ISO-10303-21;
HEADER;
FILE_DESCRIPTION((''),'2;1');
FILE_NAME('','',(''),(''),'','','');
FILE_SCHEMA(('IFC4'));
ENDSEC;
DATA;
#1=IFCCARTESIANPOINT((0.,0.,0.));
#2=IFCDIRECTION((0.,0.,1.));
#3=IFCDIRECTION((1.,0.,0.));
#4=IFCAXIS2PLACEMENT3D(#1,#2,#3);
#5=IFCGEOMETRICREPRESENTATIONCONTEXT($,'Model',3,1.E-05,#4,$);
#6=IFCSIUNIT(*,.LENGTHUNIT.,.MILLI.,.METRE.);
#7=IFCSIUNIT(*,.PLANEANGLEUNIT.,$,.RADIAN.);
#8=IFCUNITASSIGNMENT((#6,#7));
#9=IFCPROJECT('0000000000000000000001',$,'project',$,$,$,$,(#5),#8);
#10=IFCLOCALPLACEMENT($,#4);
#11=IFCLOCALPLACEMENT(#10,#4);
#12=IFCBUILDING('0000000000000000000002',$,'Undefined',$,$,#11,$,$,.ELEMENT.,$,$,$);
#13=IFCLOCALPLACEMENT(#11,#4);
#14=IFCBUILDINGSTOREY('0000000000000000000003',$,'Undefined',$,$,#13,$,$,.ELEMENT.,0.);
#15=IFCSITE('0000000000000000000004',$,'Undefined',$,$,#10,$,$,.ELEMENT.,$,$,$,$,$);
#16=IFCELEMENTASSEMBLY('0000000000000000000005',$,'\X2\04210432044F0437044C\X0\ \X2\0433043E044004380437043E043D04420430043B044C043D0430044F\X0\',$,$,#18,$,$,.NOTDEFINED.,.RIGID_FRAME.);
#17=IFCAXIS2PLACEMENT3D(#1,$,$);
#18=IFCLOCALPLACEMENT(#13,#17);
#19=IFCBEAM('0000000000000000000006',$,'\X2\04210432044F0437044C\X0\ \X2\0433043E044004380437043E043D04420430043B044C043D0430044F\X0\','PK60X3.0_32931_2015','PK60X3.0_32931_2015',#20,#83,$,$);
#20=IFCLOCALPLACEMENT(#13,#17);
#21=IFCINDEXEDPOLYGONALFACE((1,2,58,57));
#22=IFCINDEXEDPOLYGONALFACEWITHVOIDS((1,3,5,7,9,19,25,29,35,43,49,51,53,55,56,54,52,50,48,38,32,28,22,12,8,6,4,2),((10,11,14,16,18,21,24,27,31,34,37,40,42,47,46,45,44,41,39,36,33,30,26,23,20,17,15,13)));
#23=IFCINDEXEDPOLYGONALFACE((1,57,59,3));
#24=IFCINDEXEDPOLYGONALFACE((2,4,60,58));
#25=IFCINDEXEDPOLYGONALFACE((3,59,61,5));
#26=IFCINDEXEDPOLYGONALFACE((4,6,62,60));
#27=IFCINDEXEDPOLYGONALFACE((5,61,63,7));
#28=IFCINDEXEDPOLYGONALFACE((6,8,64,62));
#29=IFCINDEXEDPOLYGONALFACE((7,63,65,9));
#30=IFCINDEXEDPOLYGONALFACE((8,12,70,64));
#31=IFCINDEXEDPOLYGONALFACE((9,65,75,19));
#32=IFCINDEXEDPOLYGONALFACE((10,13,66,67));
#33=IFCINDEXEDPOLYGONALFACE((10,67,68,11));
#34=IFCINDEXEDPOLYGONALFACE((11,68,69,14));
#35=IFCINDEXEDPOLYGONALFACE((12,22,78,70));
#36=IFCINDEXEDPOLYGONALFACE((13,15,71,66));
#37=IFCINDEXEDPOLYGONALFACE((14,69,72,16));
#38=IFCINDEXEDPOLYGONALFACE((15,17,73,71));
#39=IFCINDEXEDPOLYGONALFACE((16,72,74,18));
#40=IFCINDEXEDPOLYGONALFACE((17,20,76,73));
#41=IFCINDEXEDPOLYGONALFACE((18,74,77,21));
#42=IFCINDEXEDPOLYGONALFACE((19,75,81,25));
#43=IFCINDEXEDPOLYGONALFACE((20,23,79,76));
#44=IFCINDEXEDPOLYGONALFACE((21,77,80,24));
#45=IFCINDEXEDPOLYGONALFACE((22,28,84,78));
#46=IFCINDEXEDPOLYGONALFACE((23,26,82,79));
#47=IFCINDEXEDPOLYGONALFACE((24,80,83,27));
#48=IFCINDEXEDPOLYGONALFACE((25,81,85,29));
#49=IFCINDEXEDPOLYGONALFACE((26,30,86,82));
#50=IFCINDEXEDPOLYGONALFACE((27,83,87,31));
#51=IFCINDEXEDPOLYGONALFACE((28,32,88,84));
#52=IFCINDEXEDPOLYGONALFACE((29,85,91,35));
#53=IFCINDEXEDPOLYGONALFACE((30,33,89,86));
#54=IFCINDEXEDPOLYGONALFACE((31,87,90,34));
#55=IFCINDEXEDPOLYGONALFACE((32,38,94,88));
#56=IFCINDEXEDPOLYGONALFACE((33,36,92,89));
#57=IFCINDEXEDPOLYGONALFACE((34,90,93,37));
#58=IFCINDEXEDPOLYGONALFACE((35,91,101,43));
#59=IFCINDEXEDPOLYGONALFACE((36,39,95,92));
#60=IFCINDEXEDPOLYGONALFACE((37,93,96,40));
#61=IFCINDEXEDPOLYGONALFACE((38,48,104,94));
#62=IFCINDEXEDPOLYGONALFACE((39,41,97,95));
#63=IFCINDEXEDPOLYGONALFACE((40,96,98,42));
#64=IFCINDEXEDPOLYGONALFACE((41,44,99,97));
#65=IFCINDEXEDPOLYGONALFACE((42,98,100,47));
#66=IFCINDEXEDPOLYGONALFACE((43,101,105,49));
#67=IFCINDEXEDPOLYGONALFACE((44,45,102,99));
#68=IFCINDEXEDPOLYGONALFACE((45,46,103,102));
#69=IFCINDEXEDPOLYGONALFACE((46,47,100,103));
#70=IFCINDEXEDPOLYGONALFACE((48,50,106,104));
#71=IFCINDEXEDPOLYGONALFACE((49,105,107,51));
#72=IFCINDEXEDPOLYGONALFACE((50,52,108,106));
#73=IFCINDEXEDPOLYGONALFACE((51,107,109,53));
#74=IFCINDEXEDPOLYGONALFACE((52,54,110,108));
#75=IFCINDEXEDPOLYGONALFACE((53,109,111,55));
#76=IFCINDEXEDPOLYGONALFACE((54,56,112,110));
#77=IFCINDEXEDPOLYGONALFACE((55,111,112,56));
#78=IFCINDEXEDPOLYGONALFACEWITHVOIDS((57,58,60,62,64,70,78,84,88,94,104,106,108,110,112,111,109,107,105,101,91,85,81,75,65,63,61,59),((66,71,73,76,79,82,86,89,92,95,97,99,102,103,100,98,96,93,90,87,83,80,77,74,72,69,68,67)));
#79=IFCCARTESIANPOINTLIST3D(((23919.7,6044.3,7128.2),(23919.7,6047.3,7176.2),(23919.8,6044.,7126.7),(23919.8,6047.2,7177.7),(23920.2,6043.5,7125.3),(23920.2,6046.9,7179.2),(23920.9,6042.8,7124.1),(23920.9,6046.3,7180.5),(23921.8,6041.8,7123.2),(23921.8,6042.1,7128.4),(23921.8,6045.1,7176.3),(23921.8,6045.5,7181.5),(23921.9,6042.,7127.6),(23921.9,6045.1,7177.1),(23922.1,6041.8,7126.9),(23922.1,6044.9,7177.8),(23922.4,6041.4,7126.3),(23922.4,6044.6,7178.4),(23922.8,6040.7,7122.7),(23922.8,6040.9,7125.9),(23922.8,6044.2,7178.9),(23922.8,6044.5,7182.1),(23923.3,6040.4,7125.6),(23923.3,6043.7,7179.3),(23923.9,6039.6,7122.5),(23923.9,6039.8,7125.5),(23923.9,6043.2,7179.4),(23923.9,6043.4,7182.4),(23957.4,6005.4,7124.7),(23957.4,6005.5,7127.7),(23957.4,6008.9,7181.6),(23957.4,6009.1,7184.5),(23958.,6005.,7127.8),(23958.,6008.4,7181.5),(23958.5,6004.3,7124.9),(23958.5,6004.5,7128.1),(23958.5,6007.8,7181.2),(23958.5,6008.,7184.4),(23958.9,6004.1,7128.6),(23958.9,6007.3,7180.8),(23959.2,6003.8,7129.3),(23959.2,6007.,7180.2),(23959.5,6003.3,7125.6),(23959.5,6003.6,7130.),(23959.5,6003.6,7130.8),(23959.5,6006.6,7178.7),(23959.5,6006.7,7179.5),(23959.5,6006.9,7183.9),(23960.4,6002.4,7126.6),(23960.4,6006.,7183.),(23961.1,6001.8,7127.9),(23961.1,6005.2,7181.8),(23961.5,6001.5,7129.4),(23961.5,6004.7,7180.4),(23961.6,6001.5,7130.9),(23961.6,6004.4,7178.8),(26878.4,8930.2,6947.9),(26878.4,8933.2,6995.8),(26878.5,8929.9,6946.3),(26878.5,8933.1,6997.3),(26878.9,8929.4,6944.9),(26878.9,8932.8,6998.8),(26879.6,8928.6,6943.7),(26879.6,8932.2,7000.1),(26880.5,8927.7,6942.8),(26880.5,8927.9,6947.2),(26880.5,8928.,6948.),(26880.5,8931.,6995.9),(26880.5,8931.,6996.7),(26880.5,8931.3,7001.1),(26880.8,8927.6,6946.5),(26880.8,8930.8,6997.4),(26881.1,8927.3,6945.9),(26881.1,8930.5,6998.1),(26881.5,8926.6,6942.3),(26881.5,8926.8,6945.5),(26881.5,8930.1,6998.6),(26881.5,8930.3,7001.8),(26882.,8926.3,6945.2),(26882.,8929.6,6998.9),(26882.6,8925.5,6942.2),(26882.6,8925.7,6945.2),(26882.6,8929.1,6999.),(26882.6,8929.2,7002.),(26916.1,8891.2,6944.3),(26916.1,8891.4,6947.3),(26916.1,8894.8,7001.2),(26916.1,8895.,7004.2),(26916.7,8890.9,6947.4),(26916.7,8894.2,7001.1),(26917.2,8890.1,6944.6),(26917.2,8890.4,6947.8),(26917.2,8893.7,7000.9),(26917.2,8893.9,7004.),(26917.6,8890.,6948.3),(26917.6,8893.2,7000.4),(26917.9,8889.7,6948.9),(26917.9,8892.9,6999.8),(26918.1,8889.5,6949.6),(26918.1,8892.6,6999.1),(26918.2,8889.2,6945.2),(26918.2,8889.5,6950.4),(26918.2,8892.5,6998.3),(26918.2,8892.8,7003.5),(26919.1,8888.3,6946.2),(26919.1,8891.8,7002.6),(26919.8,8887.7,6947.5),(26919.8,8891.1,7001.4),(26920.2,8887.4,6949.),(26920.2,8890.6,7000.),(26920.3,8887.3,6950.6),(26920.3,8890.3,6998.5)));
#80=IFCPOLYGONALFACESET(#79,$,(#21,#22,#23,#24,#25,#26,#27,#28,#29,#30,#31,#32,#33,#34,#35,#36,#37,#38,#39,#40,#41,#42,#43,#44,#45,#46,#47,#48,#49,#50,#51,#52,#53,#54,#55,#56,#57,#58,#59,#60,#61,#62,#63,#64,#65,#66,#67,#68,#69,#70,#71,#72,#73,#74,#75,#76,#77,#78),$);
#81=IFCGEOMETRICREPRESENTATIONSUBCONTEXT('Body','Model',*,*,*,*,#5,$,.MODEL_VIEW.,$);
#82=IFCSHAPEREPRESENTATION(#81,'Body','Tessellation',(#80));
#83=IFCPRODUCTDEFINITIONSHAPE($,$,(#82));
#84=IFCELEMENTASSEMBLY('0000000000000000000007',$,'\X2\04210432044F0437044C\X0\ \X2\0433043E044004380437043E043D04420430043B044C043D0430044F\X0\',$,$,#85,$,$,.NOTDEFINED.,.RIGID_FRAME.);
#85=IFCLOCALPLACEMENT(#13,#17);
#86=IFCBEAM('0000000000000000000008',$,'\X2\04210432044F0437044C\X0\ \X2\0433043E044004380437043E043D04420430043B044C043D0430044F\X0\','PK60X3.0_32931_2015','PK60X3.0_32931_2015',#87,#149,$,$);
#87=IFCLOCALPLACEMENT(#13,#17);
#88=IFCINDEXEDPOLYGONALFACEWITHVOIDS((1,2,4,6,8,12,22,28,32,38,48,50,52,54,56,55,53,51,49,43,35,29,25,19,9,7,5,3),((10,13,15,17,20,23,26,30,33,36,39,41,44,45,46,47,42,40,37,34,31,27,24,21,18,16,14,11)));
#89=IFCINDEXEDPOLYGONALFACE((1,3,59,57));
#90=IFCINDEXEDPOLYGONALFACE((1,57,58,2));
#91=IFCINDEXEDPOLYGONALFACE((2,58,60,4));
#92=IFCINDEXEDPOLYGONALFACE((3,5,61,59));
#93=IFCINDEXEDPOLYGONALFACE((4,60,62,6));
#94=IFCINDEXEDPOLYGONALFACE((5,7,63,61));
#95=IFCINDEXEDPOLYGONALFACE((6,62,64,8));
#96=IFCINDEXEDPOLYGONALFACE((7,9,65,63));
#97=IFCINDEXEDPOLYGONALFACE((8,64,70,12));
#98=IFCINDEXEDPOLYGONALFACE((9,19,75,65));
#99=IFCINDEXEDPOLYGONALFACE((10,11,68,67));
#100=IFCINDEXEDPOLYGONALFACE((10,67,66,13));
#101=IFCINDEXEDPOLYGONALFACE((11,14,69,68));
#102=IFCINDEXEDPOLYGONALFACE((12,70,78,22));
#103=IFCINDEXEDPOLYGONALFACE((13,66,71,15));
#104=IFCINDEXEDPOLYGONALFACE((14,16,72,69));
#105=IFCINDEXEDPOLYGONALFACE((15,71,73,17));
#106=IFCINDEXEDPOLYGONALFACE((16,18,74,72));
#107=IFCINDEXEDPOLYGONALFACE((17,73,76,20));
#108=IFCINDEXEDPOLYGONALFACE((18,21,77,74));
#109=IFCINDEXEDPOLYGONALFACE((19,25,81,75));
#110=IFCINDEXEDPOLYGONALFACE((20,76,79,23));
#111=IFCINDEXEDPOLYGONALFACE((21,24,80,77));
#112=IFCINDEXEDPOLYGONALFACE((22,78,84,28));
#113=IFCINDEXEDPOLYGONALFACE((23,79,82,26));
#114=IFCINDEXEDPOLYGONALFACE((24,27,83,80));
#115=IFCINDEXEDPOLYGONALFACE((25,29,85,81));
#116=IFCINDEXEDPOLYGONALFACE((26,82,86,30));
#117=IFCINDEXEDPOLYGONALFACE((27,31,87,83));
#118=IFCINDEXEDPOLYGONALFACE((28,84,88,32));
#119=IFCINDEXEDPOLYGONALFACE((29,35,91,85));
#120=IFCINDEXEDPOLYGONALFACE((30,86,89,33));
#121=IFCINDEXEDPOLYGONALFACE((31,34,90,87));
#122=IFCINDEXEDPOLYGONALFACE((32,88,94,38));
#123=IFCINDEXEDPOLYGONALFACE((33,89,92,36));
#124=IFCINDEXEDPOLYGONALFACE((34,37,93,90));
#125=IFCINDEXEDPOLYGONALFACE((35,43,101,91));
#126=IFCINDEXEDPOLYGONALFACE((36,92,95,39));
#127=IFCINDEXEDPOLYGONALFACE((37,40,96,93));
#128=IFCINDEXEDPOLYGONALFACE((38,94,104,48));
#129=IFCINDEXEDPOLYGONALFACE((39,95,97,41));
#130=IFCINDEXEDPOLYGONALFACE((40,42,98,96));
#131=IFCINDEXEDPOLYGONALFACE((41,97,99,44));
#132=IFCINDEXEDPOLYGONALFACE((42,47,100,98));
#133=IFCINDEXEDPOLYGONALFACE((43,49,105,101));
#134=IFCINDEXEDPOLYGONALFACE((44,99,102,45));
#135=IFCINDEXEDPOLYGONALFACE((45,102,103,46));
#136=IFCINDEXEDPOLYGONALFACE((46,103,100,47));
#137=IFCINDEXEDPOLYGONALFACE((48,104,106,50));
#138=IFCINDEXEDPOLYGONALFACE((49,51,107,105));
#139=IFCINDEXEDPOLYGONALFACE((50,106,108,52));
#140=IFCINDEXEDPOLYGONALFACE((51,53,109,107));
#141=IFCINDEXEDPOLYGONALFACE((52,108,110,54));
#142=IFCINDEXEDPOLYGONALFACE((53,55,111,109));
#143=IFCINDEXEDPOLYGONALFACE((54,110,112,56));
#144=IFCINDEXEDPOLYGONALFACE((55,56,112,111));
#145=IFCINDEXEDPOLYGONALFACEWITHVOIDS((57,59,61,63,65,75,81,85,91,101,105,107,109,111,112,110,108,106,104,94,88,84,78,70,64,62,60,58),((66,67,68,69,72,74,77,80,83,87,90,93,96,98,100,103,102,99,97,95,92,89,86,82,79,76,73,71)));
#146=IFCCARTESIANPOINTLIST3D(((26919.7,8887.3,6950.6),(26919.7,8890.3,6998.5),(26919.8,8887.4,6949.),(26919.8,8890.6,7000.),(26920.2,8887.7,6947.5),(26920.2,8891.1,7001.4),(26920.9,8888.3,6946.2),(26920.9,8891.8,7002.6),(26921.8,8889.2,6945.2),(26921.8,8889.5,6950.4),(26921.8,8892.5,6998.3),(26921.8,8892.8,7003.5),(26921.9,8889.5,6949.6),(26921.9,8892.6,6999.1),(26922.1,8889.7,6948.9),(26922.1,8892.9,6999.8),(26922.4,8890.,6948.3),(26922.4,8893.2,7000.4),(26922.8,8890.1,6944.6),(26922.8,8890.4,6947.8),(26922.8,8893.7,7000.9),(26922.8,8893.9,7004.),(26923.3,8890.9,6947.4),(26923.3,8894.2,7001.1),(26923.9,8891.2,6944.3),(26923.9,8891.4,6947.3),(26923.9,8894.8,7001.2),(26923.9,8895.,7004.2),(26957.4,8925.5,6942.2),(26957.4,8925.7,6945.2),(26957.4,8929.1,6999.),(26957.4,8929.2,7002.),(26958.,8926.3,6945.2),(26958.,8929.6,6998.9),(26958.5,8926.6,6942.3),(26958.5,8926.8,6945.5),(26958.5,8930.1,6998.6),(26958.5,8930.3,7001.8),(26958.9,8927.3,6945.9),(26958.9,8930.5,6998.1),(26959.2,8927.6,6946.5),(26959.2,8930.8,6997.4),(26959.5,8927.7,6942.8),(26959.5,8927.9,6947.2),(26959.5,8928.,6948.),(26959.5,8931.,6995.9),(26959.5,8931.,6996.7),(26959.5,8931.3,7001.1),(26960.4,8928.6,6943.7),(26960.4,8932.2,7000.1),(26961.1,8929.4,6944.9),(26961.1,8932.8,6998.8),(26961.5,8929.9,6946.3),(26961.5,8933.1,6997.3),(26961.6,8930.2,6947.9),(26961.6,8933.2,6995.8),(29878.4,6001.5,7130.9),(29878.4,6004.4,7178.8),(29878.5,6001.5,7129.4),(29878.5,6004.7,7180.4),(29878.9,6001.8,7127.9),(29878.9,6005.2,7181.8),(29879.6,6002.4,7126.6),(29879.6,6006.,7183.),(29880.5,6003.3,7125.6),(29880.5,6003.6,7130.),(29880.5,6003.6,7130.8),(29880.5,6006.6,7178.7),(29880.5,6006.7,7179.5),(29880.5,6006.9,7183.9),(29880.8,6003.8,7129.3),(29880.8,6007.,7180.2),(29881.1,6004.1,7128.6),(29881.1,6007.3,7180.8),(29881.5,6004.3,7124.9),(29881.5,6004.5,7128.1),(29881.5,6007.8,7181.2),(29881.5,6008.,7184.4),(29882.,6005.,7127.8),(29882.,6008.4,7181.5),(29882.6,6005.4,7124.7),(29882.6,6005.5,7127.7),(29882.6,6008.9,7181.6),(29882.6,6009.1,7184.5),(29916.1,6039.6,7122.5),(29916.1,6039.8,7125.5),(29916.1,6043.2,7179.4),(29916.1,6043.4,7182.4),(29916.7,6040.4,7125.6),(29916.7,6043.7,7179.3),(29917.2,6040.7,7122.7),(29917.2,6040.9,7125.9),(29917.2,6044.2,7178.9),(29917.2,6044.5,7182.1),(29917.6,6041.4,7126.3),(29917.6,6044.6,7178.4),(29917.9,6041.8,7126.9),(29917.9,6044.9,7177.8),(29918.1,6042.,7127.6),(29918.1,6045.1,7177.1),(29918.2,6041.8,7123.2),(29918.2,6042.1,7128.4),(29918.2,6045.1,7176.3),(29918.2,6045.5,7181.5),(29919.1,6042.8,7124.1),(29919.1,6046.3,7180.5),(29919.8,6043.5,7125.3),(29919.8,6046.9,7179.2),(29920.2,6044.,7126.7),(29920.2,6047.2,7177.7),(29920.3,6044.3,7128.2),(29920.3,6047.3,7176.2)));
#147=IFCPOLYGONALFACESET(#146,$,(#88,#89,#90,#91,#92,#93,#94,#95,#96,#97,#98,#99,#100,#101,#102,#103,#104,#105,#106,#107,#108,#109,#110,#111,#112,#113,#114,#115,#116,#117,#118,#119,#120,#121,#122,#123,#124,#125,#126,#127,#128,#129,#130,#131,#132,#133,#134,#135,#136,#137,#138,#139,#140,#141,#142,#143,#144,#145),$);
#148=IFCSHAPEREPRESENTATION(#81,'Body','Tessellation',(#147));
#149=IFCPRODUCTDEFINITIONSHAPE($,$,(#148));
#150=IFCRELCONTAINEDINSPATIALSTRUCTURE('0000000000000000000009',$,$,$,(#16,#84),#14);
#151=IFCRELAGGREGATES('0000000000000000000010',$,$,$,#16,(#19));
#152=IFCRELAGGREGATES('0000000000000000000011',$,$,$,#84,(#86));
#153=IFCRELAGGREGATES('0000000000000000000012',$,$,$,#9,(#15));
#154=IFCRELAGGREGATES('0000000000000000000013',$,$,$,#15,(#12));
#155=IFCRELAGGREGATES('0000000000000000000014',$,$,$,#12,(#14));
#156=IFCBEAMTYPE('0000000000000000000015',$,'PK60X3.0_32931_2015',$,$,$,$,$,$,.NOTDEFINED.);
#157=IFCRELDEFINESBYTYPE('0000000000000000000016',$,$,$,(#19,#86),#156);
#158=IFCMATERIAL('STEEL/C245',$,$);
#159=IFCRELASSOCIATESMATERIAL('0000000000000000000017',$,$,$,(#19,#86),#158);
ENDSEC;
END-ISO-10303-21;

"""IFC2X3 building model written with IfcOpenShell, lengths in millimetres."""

from ifc_helpers import new_model, si_unit, frame, origin_with_axes, origin_2d_with_axis, place, context, subcontext, project, spatial, hollow_rectangle, extrude, material, type_object, element, aggregate, save


model = new_model("IFC2X3")

# Units and contexts
model_context = context("Model", 3, precision=1e-05, world=origin_with_axes())
body_context = subcontext(model_context, "Body", "Model", "MODEL_VIEW")
ifc_project = project(units=[si_unit("LENGTHUNIT", "METRE", prefix="MILLI"), si_unit("PLANEANGLEUNIT", "RADIAN")], contexts=[model_context])

# Site, building, storey
site_placement = place(None, origin_with_axes())
site = spatial("IfcSite", under=ifc_project, at=site_placement, Name="Undefined", CompositionType="ELEMENT")
building_placement = place(site_placement, origin_with_axes())
building = spatial("IfcBuilding", under=site, at=building_placement, Name="Undefined", CompositionType="ELEMENT")
storey_placement = place(building_placement, origin_with_axes())
storey = spatial("IfcBuildingStorey", under=building, at=storey_placement, Name="Undefined", CompositionType="ELEMENT", Elevation=0.0)

# Shared definitions
ifc_material = material(Name="STEEL/C245")

# Element assemblies, beams
beam_type_1 = type_object("IfcBeamType", Name="PK60X3.0_32931_2015", PredefinedType="NOTDEFINED")
assembly_1_placement = place(storey_placement, origin_with_axes())
assembly_1 = element("IfcElementAssembly", 1, at=assembly_1_placement, inside=storey, Name="Связь горизонтальная", AssemblyPlace="NOTDEFINED", PredefinedType="RIGID_FRAME")
beam_1_placement = place(assembly_1_placement, frame((23940.7, 6024.4, 7153.5), z_axis=(0.0, 0.062378, 0.998053), x_axis=(0.715179, 0.69758, -0.043599)))
beam_1 = element("IfcBeam", 2, at=beam_1_placement, type_object=beam_type_1, material=ifc_material, Name="Связь горизонтальная", Description="PK60X3.0_32931_2015", ObjectType="PK60X3.0_32931_2015", context=body_context, shape_type="SweptSolid", body=[
    extrude(hollow_rectangle(XDim=60.0, YDim=60.0, WallThickness=3.0, InnerFilletRadius=3.0, OuterFilletRadius=6.0, at=origin_2d_with_axis()), frame((4137.0, 0.0, 0.0), z_axis=(-1.0, 0.0, 0.0), x_axis=(0.0, -1.0, 0.0)), (0.0, 0.0, 1.0), 4137.0),
])
aggregate(assembly_1, [beam_1])
assembly_2_placement = place(storey_placement, origin_with_axes())
assembly_2 = element("IfcElementAssembly", 3, at=assembly_2_placement, inside=storey, Name="Связь горизонтальная", AssemblyPlace="NOTDEFINED", PredefinedType="RIGID_FRAME")
beam_2_placement = place(assembly_2_placement, frame((29899.3, 6024.4, 7153.5), z_axis=(0.0, 0.062378, 0.998053), x_axis=(-0.715179, 0.69758, -0.043599)))
beam_2 = element("IfcBeam", 4, at=beam_2_placement, type_object=beam_type_1, material=ifc_material, Name="Связь горизонтальная", Description="PK60X3.0_32931_2015", ObjectType="PK60X3.0_32931_2015", context=body_context, shape_type="SweptSolid", body=[
    extrude(hollow_rectangle(XDim=60.0, YDim=60.0, WallThickness=3.0, InnerFilletRadius=3.0, OuterFilletRadius=6.0, at=origin_2d_with_axis()), frame((4137.0, 0.0, 0.0), z_axis=(-1.0, 0.0, 0.0), x_axis=(0.0, -1.0, 0.0)), (0.0, 0.0, 1.0), 4137.0),
])
aggregate(assembly_2, [beam_2])

save(model, "model.ifc")
